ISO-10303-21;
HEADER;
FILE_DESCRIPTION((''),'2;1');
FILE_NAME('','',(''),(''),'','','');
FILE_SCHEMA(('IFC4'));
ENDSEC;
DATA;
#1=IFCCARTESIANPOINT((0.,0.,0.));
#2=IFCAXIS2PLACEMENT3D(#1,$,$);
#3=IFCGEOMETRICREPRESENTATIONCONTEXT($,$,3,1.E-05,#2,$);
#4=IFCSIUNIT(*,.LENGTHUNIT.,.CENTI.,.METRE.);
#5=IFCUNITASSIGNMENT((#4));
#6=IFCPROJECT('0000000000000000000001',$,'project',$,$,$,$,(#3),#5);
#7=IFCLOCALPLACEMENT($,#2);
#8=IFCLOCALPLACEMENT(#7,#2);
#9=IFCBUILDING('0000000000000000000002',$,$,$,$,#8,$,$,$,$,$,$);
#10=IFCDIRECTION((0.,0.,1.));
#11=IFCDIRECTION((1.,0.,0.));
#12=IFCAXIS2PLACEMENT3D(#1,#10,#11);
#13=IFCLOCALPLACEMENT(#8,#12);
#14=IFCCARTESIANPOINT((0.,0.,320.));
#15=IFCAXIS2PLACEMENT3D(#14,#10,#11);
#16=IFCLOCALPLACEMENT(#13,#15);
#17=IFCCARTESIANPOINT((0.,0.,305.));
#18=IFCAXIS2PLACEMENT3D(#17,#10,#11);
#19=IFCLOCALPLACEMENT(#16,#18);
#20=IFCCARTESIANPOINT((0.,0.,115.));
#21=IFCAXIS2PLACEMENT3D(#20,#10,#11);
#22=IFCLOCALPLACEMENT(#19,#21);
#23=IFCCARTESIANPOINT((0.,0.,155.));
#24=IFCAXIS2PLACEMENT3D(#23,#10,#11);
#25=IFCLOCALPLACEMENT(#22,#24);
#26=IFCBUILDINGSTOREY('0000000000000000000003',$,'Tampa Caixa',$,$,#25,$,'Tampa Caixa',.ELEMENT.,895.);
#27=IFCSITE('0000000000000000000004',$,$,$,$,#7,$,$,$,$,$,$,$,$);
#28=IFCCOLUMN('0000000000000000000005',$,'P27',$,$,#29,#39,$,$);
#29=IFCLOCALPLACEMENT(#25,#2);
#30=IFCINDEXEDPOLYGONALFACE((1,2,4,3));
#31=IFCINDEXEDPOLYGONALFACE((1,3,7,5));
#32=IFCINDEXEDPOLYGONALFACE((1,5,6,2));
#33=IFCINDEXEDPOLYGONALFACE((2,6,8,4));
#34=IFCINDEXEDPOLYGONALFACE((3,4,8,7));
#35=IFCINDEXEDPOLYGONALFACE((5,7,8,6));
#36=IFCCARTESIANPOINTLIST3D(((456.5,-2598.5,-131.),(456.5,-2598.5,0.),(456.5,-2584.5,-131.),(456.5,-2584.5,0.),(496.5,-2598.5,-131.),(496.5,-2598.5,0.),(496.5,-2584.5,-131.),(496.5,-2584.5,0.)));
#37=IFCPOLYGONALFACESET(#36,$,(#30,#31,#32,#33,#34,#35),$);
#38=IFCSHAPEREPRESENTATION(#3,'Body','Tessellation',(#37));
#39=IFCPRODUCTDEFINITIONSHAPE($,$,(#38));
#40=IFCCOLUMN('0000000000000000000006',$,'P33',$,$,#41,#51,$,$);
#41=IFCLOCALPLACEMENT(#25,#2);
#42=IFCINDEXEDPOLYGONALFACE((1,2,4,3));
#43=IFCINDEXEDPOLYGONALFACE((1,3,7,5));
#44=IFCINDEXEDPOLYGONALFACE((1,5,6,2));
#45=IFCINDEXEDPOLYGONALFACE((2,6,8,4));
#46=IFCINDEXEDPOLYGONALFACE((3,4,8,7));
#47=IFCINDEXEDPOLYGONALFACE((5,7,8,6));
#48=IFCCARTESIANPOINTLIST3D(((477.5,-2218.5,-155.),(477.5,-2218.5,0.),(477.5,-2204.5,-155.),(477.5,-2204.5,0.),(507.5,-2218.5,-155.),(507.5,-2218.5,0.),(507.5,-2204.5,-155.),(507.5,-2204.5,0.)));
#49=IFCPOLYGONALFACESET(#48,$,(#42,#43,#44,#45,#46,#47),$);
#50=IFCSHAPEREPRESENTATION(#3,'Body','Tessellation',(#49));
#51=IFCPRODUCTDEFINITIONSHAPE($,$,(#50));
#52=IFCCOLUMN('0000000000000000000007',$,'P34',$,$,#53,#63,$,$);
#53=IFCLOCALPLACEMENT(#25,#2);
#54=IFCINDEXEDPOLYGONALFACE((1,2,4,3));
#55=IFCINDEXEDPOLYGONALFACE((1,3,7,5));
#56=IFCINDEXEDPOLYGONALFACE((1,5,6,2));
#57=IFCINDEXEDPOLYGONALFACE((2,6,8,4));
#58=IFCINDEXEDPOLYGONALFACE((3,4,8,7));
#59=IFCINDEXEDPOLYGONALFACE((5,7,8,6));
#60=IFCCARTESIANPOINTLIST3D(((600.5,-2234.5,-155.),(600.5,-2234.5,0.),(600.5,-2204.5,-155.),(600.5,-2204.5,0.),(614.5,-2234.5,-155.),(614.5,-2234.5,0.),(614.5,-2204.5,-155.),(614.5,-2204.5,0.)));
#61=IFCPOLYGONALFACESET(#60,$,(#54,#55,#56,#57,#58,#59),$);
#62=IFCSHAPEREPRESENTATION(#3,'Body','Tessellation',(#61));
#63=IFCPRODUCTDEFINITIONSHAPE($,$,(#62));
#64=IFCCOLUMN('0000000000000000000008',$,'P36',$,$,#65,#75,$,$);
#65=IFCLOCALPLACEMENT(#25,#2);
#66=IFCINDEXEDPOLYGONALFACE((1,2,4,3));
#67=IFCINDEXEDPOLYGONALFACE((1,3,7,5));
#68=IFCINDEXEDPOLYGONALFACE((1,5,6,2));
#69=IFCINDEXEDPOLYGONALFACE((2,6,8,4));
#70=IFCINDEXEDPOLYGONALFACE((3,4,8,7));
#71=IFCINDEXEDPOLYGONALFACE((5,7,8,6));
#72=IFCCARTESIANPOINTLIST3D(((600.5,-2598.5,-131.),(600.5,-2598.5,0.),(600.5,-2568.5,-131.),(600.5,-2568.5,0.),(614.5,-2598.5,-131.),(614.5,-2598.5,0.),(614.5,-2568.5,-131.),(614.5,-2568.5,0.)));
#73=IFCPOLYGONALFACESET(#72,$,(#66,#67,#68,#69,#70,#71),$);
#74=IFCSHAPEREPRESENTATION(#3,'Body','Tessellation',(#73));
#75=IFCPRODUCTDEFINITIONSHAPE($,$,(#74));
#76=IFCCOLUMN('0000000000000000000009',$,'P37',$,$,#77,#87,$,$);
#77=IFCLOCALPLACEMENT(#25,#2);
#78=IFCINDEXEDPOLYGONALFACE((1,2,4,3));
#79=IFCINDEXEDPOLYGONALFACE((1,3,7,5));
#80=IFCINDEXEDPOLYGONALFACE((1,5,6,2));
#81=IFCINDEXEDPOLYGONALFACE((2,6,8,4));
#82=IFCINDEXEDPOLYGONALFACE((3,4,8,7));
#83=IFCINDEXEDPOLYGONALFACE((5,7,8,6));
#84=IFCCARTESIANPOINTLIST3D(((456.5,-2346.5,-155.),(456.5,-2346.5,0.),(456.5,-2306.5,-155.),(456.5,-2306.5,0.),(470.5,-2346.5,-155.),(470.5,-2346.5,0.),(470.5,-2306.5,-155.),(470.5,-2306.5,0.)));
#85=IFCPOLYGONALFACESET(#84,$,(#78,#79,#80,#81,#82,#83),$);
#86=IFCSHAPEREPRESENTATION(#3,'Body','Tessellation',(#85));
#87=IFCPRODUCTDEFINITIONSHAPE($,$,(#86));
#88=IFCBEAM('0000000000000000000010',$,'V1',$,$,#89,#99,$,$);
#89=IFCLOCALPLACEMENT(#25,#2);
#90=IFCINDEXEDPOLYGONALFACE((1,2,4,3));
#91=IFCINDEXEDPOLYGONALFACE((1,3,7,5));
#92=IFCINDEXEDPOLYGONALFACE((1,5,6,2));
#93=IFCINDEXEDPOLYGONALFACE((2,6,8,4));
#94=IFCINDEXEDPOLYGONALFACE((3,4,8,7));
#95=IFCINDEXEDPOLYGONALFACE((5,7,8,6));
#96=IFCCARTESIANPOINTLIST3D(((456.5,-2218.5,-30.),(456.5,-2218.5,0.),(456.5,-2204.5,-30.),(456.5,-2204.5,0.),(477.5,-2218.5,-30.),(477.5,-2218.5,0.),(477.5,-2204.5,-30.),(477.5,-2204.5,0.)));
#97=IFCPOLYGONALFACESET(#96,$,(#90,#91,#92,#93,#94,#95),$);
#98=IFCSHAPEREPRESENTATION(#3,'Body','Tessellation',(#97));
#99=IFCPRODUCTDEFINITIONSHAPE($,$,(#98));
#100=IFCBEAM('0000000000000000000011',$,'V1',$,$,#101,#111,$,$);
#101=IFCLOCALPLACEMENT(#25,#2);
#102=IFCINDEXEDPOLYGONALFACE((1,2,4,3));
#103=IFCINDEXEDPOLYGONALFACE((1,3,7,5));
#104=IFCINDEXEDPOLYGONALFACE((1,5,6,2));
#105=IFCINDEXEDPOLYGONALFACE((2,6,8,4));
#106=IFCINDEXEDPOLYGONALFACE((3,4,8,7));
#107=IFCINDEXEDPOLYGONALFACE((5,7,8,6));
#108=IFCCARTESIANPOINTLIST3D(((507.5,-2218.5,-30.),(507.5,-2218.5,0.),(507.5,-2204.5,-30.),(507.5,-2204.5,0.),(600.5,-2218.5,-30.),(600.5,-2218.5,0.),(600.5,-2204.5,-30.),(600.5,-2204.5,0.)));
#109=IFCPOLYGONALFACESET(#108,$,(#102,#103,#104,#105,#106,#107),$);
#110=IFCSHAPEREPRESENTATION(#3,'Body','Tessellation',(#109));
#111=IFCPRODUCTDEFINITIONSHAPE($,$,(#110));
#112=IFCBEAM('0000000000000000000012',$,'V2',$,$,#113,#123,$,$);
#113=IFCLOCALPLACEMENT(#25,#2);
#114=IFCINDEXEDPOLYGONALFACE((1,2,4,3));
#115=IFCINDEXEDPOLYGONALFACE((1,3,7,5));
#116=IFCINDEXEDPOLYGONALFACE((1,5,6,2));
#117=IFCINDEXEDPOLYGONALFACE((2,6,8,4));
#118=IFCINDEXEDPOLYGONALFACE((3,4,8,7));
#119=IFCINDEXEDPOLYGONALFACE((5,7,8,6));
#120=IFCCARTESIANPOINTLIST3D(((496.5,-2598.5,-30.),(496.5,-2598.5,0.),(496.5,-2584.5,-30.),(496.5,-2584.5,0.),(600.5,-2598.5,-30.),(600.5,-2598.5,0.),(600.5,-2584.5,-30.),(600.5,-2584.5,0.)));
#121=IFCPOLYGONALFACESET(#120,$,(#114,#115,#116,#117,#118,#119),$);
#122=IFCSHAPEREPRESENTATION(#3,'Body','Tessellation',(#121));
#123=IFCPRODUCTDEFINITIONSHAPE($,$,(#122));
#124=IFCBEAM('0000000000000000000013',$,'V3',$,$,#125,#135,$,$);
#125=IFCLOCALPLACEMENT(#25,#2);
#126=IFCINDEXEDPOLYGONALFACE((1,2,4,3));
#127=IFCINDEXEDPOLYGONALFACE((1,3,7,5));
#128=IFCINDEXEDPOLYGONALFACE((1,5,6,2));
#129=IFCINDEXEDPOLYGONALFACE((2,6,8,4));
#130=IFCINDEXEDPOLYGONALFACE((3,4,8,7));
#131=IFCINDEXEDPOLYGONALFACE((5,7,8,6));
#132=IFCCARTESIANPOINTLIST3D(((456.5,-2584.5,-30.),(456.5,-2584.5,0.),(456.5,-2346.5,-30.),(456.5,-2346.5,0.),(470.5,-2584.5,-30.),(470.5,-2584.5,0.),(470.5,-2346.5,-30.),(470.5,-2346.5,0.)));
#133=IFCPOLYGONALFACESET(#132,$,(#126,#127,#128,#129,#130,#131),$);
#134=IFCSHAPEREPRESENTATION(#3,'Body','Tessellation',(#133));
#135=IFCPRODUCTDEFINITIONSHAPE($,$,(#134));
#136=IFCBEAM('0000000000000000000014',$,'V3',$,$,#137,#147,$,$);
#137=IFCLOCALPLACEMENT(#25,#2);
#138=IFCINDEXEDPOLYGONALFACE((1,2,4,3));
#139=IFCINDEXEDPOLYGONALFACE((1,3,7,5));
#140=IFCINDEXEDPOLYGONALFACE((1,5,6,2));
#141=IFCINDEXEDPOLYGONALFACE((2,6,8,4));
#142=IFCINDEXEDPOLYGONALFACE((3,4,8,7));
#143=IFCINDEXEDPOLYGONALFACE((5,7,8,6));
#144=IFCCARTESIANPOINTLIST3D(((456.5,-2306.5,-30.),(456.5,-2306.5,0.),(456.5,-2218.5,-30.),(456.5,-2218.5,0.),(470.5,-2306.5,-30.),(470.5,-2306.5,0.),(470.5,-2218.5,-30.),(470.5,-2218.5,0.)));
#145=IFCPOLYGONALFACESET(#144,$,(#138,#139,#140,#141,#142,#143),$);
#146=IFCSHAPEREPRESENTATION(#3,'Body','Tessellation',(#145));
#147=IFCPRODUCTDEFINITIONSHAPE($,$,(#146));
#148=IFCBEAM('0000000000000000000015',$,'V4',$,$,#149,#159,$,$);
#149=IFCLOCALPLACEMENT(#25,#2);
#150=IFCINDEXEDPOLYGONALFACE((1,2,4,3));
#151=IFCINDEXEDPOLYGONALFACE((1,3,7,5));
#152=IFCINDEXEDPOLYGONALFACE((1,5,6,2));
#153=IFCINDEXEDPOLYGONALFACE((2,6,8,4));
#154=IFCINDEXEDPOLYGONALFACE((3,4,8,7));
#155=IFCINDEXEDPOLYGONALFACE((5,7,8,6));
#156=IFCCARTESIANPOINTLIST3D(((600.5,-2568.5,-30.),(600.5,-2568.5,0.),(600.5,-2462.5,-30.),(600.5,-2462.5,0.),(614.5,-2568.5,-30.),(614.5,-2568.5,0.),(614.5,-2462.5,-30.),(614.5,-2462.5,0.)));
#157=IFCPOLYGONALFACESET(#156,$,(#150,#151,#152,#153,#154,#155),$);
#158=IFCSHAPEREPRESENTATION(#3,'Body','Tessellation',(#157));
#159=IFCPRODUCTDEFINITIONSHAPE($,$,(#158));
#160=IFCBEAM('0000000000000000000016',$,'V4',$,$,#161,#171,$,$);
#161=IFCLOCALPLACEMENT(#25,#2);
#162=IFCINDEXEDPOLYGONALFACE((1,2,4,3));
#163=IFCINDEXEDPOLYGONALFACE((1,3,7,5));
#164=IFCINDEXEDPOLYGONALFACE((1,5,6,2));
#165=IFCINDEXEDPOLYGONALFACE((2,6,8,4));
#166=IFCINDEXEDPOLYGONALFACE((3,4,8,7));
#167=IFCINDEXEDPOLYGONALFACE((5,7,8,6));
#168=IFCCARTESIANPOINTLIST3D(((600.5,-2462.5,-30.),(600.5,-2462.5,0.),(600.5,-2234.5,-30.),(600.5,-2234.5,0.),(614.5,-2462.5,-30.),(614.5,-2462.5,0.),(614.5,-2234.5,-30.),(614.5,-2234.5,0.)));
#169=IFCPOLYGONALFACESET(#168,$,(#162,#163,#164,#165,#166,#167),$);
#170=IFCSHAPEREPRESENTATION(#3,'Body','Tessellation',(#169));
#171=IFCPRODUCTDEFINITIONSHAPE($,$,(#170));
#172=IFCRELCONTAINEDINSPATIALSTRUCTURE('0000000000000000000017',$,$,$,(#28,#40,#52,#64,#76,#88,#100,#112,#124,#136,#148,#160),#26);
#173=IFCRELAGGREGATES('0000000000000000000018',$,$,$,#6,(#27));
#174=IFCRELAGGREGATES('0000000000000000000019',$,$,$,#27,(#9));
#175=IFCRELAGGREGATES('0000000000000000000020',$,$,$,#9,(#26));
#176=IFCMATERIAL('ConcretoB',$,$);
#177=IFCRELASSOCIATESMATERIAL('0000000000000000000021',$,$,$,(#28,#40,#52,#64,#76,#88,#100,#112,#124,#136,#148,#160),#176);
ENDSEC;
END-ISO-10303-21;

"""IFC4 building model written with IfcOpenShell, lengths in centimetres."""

from ifc_helpers import new_model, si_unit, frame, origin, origin_with_axes, place, context, project, spatial, polyline, outline, extrude, material, element, save


model = new_model("IFC4")

# Units and contexts
context_of_model = context(None, 3, precision=1e-05, world=origin())
ifc_project = project(units=[si_unit("LENGTHUNIT", "METRE", prefix="CENTI")], contexts=[context_of_model])

# Site, building, storey
site_placement = place(None, origin())
site = spatial("IfcSite", under=ifc_project, at=site_placement)
building_placement = place(site_placement, origin())
building = spatial("IfcBuilding", under=site, at=building_placement)
placement_1 = place(building_placement, origin_with_axes())
placement_2 = place(placement_1, frame((0.0, 0.0, 320.0), z_axis=(0.0, 0.0, 1.0), x_axis=(1.0, 0.0, 0.0)))
placement_3 = place(placement_2, frame((0.0, 0.0, 305.0), z_axis=(0.0, 0.0, 1.0), x_axis=(1.0, 0.0, 0.0)))
placement_4 = place(placement_3, frame((0.0, 0.0, 115.0), z_axis=(0.0, 0.0, 1.0), x_axis=(1.0, 0.0, 0.0)))
storey_placement = place(placement_4, frame((0.0, 0.0, 155.0), z_axis=(0.0, 0.0, 1.0), x_axis=(1.0, 0.0, 0.0)))
storey = spatial("IfcBuildingStorey", under=building, at=storey_placement, Name="Tampa Caixa", LongName="Tampa Caixa", CompositionType="ELEMENT", Elevation=895.0)

# Columns
ifc_material = material(Name="ConcretoB")
column_1_placement = place(storey_placement, frame((476.5, -2591.5, 0.0), z_axis=(0.0, 0.0, 1.0), x_axis=(1.0, 0.0, 0.0)))
element("IfcColumn", 1, at=column_1_placement, inside=storey, material=ifc_material, Name="P27", context=context_of_model, shape_type="SolidModel", body=[
    extrude(outline(polyline([(20.0, -7.0), (20.0, 7.0), (-20.0, 7.0), (-20.0, -7.0), (20.0, -7.0)])), origin_with_axes(), (0.0, 0.0, -1.0), 131.0),
])
column_2_placement = place(storey_placement, frame((492.5, -2211.5, 0.0), z_axis=(0.0, 0.0, 1.0), x_axis=(1.0, 0.0, 0.0)))
element("IfcColumn", 2, at=column_2_placement, inside=storey, material=ifc_material, Name="P33", context=context_of_model, shape_type="SolidModel", body=[
    extrude(outline(polyline([(15.0, -7.0), (15.0, 7.0), (-15.0, 7.0), (-15.0, -7.0), (15.0, -7.0)])), origin_with_axes(), (0.0, 0.0, -1.0), 155.0),
])
column_3_placement = place(storey_placement, frame((607.5, -2219.5, 0.0), z_axis=(0.0, 0.0, 1.0), x_axis=(1.0, 0.0, 0.0)))
element("IfcColumn", 3, at=column_3_placement, inside=storey, material=ifc_material, Name="P34", context=context_of_model, shape_type="SolidModel", body=[
    extrude(outline(polyline([(7.0, 15.0), (-7.0, 15.0), (-7.0, -15.0), (7.0, -15.0), (7.0, 15.0)])), origin_with_axes(), (0.0, 0.0, -1.0), 155.0),
])
column_4_placement = place(storey_placement, frame((607.5, -2583.5, 0.0), z_axis=(0.0, 0.0, 1.0), x_axis=(1.0, 0.0, 0.0)))
element("IfcColumn", 4, at=column_4_placement, inside=storey, material=ifc_material, Name="P36", context=context_of_model, shape_type="SolidModel", body=[
    extrude(outline(polyline([(7.0, 15.0), (-7.0, 15.0), (-7.0, -15.0), (7.0, -15.0), (7.0, 15.0)])), origin_with_axes(), (0.0, 0.0, -1.0), 131.0),
])
column_5_placement = place(storey_placement, frame((463.5, -2326.5, 0.0), z_axis=(0.0, 0.0, 1.0), x_axis=(1.0, 0.0, 0.0)))
element("IfcColumn", 5, at=column_5_placement, inside=storey, material=ifc_material, Name="P37", context=context_of_model, shape_type="SolidModel", body=[
    extrude(outline(polyline([(-7.0, -20.0), (7.0, -20.0), (7.0, 20.0), (-7.0, 20.0), (-7.0, -20.0)])), origin_with_axes(), (0.0, 0.0, -1.0), 155.0),
])

# Beams
beam_1_placement = place(storey_placement, frame((467.0, -2211.5, 0.0), z_axis=(0.0, 0.0, 1.0), x_axis=(1.0, 0.0, 0.0)))
element("IfcBeam", 6, at=beam_1_placement, inside=storey, material=ifc_material, Name="V1", context=context_of_model, shape_type="SolidModel", body=[
    extrude(outline(polyline([(-7.0, -15.0), (7.0, -15.0), (7.0, 15.0), (-7.0, 15.0), (-7.0, -15.0)])), frame((-10.5, 0.0, -15.0), z_axis=(1.0, 0.0, 0.0), x_axis=(0.0, -1.0, 0.0)), (0.0, 0.0, 1.0), 21.0),
])
beam_2_placement = place(storey_placement, frame((554.0, -2211.5, 0.0), z_axis=(0.0, 0.0, 1.0), x_axis=(1.0, 0.0, 0.0)))
element("IfcBeam", 7, at=beam_2_placement, inside=storey, material=ifc_material, Name="V1", context=context_of_model, shape_type="SolidModel", body=[
    extrude(outline(polyline([(-7.0, -15.0), (7.0, -15.0), (7.0, 15.0), (-7.0, 15.0), (-7.0, -15.0)])), frame((-46.5, 0.0, -15.0), z_axis=(1.0, 0.0, 0.0), x_axis=(0.0, -1.0, 0.0)), (0.0, 0.0, 1.0), 93.0),
])
beam_3_placement = place(storey_placement, frame((548.5, -2591.5, 0.0), z_axis=(0.0, 0.0, 1.0), x_axis=(1.0, 0.0, 0.0)))
element("IfcBeam", 8, at=beam_3_placement, inside=storey, material=ifc_material, Name="V2", context=context_of_model, shape_type="SolidModel", body=[
    extrude(outline(polyline([(-7.0, -15.0), (7.0, -15.0), (7.0, 15.0), (-7.0, 15.0), (-7.0, -15.0)])), frame((-52.0, 0.0, -15.0), z_axis=(1.0, 0.0, 0.0), x_axis=(0.0, -1.0, 0.0)), (0.0, 0.0, 1.0), 104.0),
])
beam_4_placement = place(storey_placement, frame((463.5, -2465.5, 0.0), z_axis=(0.0, 0.0, 1.0), x_axis=(1.0, 0.0, 0.0)))
element("IfcBeam", 9, at=beam_4_placement, inside=storey, material=ifc_material, Name="V3", context=context_of_model, shape_type="SolidModel", body=[
    extrude(outline(polyline([(-7.0, -15.0), (7.0, -15.0), (7.0, 15.0), (-7.0, 15.0), (-7.0, -15.0)])), frame((0.0, -119.0, -15.0), z_axis=(0.0, 1.0, 0.0), x_axis=(1.0, 0.0, 0.0)), (0.0, 0.0, 1.0), 238.0),
])
beam_5_placement = place(storey_placement, frame((463.5, -2262.5, 0.0), z_axis=(0.0, 0.0, 1.0), x_axis=(1.0, 0.0, 0.0)))
element("IfcBeam", 10, at=beam_5_placement, inside=storey, material=ifc_material, Name="V3", context=context_of_model, shape_type="SolidModel", body=[
    extrude(outline(polyline([(-7.0, -15.0), (7.0, -15.0), (7.0, 15.0), (-7.0, 15.0), (-7.0, -15.0)])), frame((0.0, -44.0, -15.0), z_axis=(0.0, 1.0, 0.0), x_axis=(1.0, 0.0, 0.0)), (0.0, 0.0, 1.0), 88.0),
])
beam_6_placement = place(storey_placement, frame((607.5, -2515.5, 0.0), z_axis=(0.0, 0.0, 1.0), x_axis=(1.0, 0.0, 0.0)))
element("IfcBeam", 11, at=beam_6_placement, inside=storey, material=ifc_material, Name="V4", context=context_of_model, shape_type="SolidModel", body=[
    extrude(outline(polyline([(-7.0, -15.0), (7.0, -15.0), (7.0, 15.0), (-7.0, 15.0), (-7.0, -15.0)])), frame((0.0, -53.0, -15.0), z_axis=(0.0, 1.0, 0.0), x_axis=(1.0, 0.0, 0.0)), (0.0, 0.0, 1.0), 106.0),
])
beam_7_placement = place(storey_placement, frame((607.5, -2348.5, 0.0), z_axis=(0.0, 0.0, 1.0), x_axis=(1.0, 0.0, 0.0)))
element("IfcBeam", 12, at=beam_7_placement, inside=storey, material=ifc_material, Name="V4", context=context_of_model, shape_type="SolidModel", body=[
    extrude(outline(polyline([(-7.0, -15.0), (7.0, -15.0), (7.0, 15.0), (-7.0, 15.0), (-7.0, -15.0)])), frame((0.0, -114.0, -15.0), z_axis=(0.0, 1.0, 0.0), x_axis=(1.0, 0.0, 0.0)), (0.0, 0.0, 1.0), 228.0),
])

save(model, "model.ifc")
